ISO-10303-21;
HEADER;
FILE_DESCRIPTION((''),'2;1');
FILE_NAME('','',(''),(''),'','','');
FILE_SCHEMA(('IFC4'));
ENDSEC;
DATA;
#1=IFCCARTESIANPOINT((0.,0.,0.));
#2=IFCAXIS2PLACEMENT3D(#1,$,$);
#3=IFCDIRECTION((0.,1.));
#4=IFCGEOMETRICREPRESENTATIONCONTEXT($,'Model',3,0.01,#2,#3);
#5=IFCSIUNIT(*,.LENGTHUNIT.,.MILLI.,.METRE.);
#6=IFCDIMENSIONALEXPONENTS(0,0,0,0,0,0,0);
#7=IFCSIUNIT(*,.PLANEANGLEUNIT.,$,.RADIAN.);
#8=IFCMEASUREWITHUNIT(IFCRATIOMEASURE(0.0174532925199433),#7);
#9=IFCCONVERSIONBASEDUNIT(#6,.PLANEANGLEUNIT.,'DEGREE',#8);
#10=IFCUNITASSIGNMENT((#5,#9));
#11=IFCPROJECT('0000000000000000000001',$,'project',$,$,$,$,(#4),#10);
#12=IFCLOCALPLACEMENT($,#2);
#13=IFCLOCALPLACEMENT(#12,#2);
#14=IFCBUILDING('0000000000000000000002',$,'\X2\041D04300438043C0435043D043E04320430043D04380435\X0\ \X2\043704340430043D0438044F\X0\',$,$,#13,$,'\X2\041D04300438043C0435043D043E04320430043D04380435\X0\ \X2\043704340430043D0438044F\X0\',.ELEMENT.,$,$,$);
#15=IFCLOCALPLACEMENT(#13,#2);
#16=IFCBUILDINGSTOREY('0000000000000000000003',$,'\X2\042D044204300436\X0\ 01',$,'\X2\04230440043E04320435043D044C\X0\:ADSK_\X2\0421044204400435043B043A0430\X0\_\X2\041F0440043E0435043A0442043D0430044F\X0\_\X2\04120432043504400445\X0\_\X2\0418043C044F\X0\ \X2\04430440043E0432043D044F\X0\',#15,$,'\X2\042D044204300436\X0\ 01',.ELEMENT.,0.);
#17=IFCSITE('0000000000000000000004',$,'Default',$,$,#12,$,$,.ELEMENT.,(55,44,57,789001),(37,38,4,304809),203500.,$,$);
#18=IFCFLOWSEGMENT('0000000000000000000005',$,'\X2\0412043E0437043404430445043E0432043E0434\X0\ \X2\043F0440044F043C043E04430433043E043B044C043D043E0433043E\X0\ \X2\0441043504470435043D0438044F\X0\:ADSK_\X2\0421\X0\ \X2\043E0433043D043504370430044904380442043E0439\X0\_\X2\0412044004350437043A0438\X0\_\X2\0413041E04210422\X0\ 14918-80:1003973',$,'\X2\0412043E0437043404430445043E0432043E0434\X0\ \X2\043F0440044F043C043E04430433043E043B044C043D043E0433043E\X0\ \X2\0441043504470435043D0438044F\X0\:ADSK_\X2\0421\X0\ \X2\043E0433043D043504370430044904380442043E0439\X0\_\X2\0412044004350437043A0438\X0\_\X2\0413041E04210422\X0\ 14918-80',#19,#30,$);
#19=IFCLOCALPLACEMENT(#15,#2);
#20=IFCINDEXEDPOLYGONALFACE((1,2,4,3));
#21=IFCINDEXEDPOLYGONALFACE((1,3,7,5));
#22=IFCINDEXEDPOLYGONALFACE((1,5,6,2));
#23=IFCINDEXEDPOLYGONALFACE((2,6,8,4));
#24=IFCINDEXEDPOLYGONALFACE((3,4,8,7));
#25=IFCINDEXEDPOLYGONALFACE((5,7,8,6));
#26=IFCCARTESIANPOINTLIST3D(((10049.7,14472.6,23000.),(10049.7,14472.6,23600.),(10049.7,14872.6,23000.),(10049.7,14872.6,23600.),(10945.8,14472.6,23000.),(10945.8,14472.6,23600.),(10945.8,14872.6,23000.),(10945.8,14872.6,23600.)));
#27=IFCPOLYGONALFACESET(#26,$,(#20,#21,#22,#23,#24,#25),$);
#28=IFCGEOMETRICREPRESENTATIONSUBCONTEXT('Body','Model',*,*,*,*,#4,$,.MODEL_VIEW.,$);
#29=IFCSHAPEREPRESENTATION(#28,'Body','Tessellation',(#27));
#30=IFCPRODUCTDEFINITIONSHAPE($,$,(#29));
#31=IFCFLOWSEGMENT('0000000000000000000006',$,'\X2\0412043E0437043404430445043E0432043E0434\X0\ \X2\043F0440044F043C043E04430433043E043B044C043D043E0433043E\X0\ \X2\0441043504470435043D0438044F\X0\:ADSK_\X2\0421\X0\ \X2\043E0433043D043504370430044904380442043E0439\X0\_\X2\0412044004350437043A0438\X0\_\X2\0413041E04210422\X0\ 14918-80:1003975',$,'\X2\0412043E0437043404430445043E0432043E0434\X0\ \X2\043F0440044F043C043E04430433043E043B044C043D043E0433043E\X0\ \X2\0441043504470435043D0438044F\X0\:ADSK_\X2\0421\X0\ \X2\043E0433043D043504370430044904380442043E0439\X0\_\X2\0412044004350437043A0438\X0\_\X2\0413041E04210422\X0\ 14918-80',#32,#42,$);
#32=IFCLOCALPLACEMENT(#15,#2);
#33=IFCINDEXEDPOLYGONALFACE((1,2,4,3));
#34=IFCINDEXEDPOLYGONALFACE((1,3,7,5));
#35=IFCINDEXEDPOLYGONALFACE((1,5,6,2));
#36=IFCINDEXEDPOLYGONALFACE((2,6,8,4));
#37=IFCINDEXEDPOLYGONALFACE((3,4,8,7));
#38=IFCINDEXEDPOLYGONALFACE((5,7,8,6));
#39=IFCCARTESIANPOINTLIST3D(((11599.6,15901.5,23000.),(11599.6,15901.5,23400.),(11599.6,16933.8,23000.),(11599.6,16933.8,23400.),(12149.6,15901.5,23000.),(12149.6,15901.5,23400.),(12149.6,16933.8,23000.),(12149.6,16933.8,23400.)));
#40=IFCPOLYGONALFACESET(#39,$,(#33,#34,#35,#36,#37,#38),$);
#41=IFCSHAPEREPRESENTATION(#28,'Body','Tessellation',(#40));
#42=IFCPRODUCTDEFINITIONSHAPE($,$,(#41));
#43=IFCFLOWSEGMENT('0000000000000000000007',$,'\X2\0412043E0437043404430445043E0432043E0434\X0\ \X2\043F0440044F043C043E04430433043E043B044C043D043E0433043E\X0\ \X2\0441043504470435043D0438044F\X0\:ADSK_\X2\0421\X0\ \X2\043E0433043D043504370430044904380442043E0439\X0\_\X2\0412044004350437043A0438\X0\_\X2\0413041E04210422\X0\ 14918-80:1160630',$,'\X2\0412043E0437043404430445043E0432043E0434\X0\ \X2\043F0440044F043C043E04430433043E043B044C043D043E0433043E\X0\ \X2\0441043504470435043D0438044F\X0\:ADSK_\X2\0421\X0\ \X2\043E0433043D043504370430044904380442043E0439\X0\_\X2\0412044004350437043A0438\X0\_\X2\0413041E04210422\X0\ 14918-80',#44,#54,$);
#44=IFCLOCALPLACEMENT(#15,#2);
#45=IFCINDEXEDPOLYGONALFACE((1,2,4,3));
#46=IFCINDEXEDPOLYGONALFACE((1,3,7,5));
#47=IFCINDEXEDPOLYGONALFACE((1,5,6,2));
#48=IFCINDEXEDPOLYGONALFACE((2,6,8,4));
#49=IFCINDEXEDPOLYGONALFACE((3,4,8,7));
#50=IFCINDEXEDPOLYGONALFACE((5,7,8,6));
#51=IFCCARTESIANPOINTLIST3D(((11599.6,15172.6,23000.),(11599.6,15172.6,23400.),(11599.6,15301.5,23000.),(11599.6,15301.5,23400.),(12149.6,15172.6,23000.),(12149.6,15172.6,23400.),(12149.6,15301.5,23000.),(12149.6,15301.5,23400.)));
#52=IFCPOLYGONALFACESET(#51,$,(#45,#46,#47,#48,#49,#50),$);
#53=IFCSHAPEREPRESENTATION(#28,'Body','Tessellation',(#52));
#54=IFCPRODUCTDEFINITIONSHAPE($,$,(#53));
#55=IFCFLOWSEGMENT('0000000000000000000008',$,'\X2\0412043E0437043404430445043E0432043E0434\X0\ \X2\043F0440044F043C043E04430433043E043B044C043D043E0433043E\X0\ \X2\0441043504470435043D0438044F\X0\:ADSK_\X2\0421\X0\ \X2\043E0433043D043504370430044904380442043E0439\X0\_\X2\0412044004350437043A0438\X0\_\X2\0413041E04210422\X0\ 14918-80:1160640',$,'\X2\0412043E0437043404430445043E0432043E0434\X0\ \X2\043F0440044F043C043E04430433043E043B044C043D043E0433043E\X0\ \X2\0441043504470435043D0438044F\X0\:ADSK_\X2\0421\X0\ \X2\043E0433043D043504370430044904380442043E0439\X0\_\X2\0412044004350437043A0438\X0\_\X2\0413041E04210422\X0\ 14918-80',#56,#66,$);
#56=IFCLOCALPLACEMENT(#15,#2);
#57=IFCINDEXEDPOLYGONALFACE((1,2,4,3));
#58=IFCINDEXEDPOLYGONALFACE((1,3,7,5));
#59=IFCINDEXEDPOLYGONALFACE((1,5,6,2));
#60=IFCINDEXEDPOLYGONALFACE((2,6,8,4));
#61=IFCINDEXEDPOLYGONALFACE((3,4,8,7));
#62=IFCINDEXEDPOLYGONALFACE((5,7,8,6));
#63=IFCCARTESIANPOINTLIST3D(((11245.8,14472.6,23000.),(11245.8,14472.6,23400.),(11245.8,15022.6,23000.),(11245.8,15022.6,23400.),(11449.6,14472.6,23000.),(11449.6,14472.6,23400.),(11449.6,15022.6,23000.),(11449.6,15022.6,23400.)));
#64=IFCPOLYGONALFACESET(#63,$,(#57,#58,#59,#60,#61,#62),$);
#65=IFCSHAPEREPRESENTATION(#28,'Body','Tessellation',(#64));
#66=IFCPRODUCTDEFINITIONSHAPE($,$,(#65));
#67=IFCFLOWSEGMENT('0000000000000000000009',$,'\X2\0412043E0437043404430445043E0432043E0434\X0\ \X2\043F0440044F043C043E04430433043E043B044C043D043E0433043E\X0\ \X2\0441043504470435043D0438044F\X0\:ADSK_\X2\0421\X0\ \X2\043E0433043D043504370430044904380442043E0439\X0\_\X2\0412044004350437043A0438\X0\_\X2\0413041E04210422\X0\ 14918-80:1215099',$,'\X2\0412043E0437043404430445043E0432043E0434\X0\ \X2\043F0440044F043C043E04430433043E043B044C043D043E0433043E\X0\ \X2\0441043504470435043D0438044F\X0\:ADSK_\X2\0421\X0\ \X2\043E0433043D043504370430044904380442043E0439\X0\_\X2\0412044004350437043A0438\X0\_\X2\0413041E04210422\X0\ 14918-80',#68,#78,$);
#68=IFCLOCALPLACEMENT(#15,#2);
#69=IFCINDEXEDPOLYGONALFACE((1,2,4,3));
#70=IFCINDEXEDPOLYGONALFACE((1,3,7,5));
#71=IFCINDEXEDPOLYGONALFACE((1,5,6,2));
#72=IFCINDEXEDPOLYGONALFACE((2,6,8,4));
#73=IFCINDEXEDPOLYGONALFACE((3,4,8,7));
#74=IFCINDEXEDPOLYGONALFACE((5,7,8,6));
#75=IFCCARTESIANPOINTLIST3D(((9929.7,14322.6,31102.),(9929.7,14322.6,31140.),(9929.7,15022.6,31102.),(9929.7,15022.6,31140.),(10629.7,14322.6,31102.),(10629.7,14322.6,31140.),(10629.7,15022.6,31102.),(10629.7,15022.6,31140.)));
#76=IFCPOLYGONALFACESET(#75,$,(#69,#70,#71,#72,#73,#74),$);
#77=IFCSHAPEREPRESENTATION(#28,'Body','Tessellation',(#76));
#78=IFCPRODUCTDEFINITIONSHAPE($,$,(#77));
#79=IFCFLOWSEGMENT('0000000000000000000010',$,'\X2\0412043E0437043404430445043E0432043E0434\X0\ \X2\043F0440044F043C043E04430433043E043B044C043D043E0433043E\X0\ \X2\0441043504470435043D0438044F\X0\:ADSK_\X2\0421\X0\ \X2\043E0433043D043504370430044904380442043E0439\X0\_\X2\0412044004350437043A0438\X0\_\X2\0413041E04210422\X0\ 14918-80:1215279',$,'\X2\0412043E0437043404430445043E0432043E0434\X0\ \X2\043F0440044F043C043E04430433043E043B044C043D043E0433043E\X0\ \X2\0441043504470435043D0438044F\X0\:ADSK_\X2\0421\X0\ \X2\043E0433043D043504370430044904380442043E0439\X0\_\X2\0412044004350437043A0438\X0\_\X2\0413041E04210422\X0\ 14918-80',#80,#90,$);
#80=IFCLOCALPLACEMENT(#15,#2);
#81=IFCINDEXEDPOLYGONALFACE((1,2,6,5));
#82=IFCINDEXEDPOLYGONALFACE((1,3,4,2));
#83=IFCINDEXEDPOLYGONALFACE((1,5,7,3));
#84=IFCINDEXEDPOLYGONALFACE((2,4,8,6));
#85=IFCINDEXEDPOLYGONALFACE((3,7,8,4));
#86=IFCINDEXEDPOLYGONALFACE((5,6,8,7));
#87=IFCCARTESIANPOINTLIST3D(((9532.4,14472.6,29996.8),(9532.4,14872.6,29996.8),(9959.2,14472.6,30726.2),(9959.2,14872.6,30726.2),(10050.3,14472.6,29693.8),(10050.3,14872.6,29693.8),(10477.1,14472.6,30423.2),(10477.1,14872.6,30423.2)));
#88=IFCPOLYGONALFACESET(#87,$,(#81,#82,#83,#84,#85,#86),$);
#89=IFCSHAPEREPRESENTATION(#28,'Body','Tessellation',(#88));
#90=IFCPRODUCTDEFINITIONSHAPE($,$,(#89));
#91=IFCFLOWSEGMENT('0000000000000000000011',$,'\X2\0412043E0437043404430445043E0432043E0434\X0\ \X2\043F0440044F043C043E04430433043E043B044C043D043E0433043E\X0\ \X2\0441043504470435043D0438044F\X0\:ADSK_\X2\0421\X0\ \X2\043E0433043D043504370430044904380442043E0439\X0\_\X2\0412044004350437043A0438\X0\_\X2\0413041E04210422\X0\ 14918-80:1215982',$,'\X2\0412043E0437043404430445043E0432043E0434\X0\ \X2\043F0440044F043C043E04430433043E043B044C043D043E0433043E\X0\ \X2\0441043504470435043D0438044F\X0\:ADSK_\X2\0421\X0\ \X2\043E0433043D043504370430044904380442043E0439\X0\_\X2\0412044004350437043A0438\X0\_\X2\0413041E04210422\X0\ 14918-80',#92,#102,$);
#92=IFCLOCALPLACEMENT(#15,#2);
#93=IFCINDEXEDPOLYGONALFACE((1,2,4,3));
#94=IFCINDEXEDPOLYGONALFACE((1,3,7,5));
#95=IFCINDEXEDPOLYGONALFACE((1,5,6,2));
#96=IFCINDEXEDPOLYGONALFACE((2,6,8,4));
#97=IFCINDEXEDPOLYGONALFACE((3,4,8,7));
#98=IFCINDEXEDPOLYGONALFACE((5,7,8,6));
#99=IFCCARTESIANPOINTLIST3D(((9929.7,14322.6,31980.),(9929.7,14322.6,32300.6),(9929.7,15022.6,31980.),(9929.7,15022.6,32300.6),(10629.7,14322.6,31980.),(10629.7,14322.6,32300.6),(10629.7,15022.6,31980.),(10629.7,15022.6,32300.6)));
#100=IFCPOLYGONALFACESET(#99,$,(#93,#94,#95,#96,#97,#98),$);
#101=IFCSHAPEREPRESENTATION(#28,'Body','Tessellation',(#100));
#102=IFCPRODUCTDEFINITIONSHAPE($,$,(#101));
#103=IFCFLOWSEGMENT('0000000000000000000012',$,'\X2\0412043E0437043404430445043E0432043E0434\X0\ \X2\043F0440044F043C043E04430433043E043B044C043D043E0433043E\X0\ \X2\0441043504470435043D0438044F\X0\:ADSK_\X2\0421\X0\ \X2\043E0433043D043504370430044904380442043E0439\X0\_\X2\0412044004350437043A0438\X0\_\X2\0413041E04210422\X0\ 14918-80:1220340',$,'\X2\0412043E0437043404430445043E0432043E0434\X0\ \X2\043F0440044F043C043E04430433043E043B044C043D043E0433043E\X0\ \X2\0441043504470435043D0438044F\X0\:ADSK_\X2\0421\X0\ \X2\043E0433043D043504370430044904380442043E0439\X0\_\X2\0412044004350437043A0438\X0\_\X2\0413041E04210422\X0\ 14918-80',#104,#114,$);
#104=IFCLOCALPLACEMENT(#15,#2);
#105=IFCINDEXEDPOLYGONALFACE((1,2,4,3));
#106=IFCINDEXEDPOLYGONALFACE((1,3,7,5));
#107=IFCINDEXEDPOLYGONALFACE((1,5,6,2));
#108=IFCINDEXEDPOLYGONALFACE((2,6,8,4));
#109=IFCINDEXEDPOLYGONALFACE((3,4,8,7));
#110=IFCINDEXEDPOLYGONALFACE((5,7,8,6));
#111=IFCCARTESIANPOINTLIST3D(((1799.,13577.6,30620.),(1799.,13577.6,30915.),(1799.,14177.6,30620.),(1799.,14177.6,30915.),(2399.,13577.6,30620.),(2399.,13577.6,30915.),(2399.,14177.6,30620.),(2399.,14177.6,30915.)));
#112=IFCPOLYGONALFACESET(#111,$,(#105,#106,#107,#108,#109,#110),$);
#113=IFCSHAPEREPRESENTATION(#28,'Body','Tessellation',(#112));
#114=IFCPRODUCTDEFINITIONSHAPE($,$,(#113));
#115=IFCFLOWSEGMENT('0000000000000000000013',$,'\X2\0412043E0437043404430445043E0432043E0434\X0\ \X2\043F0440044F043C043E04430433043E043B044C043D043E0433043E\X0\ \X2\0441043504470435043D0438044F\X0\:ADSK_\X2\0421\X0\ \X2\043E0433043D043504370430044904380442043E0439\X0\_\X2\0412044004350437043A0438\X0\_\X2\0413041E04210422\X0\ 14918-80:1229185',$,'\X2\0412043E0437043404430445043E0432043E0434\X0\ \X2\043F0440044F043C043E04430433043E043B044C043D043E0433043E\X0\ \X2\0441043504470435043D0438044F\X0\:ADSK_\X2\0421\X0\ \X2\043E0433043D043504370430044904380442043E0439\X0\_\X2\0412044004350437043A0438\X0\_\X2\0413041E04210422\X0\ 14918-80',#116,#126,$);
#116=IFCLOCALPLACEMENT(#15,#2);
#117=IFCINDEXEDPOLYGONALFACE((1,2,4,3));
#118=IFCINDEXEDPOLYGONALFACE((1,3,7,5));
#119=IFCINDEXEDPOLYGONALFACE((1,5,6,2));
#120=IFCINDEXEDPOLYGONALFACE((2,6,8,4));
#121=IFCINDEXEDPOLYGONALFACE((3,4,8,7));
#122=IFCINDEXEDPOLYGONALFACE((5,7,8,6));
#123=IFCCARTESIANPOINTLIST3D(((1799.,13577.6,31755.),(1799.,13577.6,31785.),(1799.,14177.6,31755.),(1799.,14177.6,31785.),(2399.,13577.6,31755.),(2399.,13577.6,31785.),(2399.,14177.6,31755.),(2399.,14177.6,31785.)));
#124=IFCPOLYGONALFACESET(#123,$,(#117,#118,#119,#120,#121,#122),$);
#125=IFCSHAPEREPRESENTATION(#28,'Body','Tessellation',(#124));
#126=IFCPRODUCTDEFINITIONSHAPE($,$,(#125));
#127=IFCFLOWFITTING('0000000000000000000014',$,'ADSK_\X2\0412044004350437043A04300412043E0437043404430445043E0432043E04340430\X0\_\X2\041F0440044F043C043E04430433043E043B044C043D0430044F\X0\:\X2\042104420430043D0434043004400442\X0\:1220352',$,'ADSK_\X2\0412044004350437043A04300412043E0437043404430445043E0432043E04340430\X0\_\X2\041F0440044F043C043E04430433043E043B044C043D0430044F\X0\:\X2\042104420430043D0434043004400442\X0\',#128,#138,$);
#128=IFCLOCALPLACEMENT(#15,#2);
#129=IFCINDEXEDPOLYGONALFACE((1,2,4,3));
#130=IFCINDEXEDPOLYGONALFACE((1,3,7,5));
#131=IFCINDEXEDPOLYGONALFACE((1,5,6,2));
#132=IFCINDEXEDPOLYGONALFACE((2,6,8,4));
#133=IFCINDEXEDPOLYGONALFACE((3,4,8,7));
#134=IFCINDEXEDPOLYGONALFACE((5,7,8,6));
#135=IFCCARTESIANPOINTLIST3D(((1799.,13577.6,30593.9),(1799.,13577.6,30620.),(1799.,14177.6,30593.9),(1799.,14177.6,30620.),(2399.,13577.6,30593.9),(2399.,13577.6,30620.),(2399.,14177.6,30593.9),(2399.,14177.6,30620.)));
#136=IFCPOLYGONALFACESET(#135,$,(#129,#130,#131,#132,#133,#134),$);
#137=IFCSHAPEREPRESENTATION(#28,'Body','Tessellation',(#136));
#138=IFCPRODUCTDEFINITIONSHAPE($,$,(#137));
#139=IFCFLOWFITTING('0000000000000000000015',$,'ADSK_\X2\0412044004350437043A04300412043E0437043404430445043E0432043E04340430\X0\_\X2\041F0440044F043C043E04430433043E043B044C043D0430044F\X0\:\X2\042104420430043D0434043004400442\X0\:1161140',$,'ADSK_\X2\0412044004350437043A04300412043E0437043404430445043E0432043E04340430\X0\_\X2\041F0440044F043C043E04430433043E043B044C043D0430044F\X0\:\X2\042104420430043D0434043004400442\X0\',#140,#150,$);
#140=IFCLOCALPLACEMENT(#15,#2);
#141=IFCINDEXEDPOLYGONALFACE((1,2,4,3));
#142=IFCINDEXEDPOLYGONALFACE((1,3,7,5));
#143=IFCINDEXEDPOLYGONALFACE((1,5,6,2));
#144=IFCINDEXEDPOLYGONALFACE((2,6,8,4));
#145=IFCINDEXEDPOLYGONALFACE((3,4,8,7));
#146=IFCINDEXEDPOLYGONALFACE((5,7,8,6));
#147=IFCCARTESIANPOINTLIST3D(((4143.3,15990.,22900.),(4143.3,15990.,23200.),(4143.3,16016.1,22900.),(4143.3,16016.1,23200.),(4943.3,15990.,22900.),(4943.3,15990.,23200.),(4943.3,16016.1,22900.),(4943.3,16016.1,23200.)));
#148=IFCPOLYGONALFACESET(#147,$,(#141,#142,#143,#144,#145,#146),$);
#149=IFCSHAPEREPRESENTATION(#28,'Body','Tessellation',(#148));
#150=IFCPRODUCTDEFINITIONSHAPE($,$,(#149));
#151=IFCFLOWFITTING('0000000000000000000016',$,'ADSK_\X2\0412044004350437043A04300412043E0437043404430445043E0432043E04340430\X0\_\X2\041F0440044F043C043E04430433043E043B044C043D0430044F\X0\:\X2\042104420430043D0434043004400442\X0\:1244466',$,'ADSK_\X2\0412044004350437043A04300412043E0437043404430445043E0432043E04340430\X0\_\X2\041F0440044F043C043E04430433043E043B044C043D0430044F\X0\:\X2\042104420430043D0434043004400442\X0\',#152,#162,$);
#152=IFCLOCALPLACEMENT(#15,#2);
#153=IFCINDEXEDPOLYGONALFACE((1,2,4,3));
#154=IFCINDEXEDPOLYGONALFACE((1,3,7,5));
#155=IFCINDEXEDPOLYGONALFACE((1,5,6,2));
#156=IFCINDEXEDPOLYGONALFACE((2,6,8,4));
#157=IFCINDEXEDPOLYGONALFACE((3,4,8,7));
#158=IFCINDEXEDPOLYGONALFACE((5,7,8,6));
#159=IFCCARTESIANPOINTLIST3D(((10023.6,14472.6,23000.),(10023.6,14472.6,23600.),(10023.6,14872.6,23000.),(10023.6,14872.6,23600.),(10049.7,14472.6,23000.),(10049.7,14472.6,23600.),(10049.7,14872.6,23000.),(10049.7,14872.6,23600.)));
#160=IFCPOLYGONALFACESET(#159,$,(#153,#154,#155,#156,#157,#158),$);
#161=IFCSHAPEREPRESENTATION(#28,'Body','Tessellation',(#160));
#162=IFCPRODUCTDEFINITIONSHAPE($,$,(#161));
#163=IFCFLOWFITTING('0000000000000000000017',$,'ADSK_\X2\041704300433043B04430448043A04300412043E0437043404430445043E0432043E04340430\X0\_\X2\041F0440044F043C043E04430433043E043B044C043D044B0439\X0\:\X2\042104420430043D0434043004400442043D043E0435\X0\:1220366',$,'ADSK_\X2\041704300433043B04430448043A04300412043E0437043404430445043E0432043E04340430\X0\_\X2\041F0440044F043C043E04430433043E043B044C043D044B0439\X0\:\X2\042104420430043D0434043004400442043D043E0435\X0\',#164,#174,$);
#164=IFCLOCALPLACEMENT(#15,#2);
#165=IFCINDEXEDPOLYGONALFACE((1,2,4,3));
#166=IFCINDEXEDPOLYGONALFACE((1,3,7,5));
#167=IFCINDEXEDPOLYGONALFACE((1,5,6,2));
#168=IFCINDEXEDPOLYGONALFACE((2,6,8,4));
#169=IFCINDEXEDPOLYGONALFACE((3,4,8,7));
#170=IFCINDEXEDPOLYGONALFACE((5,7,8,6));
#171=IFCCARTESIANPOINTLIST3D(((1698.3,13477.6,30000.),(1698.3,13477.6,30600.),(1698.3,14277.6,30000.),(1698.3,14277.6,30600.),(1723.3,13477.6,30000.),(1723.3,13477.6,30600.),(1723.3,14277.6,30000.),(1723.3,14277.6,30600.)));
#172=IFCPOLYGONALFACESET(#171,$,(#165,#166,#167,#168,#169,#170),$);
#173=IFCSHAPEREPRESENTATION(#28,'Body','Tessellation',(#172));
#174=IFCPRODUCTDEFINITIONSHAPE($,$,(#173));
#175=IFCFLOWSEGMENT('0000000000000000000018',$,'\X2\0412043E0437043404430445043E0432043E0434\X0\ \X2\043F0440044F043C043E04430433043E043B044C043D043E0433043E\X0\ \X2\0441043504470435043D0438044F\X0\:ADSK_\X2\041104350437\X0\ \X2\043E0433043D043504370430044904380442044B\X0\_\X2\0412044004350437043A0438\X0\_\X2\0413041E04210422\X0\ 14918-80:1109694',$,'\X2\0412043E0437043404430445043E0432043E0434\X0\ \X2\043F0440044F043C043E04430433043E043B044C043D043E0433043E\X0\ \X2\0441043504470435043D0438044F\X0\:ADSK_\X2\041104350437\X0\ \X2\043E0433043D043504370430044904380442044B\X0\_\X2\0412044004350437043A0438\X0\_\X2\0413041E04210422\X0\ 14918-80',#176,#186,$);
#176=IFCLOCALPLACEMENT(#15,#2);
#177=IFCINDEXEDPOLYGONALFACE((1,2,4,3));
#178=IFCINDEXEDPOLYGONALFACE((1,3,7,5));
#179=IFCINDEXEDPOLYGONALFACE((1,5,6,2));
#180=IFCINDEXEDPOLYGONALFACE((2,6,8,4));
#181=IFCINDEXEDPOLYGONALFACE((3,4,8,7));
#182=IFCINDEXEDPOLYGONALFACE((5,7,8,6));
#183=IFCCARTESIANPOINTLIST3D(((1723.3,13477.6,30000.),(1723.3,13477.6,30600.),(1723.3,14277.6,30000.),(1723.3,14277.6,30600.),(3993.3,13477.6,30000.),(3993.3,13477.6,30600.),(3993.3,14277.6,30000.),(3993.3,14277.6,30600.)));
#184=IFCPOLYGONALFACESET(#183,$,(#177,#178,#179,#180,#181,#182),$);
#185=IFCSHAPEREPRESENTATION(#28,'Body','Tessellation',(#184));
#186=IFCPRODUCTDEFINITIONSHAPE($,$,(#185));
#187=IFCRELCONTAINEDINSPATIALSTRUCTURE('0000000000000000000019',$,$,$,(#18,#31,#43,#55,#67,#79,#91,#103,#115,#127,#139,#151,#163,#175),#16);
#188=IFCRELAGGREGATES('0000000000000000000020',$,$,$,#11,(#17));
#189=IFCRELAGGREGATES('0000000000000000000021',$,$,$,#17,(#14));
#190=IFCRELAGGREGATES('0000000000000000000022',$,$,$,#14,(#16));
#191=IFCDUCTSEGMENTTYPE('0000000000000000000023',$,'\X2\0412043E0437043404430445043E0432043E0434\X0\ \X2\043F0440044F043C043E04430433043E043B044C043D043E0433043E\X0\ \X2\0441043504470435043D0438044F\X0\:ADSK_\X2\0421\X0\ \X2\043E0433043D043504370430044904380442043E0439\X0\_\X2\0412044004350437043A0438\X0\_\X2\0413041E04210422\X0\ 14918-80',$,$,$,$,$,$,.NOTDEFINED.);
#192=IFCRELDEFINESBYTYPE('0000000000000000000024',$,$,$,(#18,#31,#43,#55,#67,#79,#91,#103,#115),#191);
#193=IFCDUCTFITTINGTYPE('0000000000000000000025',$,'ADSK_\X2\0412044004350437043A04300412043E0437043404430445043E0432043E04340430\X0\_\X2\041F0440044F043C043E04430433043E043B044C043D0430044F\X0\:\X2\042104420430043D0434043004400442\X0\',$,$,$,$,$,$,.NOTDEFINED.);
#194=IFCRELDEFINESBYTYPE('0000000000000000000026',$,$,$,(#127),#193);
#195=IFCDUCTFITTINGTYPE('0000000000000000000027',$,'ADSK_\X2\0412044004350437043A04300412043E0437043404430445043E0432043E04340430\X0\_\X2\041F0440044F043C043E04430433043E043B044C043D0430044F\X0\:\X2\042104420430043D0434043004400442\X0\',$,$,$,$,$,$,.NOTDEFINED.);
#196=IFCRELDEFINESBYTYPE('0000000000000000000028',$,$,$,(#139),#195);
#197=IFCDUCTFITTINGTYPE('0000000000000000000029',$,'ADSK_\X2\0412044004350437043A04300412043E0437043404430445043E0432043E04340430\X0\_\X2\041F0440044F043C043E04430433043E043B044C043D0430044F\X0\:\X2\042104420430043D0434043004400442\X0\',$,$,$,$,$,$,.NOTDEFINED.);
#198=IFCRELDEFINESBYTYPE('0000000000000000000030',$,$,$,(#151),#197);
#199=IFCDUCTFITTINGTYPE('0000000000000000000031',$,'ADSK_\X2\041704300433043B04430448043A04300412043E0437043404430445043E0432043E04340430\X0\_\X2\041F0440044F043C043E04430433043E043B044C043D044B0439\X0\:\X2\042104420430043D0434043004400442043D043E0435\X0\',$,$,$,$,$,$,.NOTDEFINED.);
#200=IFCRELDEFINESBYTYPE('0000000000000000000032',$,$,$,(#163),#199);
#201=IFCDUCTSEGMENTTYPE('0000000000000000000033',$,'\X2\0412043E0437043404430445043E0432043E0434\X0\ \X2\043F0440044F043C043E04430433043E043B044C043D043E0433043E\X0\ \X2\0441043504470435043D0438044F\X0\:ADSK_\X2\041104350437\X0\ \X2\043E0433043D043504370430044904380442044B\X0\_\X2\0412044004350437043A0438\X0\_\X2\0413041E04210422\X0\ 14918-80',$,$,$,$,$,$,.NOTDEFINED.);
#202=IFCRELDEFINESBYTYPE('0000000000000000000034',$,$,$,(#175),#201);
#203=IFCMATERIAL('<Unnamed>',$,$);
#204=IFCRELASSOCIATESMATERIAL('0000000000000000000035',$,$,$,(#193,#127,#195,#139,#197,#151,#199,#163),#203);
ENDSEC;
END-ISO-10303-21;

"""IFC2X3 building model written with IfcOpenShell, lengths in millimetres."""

from ifc_helpers import new_model, entity, si_unit, converted_unit, direction, frame, frame_2d, origin, origin_2d_with_axis, place, context, subcontext, project, spatial, rectangle, extrude, source, transform, mapped, material, type_object, type_shapes, element, save


model = new_model("IFC2X3")

# Units and contexts
model_context = context("Model", 3, precision=0.01, world=origin(), true_north=direction((0.0, 1.0)))
body_context = subcontext(model_context, "Body", "Model", "MODEL_VIEW")
ifc_project = project(units=[si_unit("LENGTHUNIT", "METRE", prefix="MILLI"), converted_unit("PLANEANGLEUNIT", "DEGREE", entity("IfcRatioMeasure", 0.0174532925199433), si_unit("PLANEANGLEUNIT", "RADIAN"), dimensions=[0, 0, 0, 0, 0, 0, 0])], contexts=[model_context])

# Site, building, storey
site_placement = place(None, frame((0.0, 0.0, 0.0)))
site = spatial("IfcSite", under=ifc_project, at=site_placement, Name="Default", CompositionType="ELEMENT", RefLatitude=(55, 44, 57, 789001), RefLongitude=(37, 38, 4, 304809), RefElevation=203500.0)
building_placement = place(site_placement, origin())
building = spatial("IfcBuilding", under=site, at=building_placement, Name="Наименование здания", LongName="Наименование здания", CompositionType="ELEMENT")
storey_placement = place(building_placement, origin())
storey = spatial("IfcBuildingStorey", under=building, at=storey_placement, Name="Этаж 01", ObjectType="Уровень:ADSK_Стрелка_Проектная_Вверх_Имя уровня", LongName="Этаж 01", CompositionType="ELEMENT", Elevation=0.0)

# Flow segments
duct_segment_type_1 = type_object("IfcDuctSegmentType", Name="Воздуховод прямоугольного сечения:ADSK_С огнезащитой_Врезки_ГОСТ 14918-80", PredefinedType="NOTDEFINED")
flow_segment_1_placement = place(storey_placement, frame((10049.7, 14472.6, 23000.0)))
element("IfcFlowSegment", 1, at=flow_segment_1_placement, inside=storey, type_object=duct_segment_type_1, Name="Воздуховод прямоугольного сечения:ADSK_С огнезащитой_Врезки_ГОСТ 14918-80:1003973", ObjectType="Воздуховод прямоугольного сечения:ADSK_С огнезащитой_Врезки_ГОСТ 14918-80", context=body_context, shape_type="SweptSolid", body=[
    extrude(rectangle(XDim=896.0, YDim=400.0, at=frame_2d((0.0, 0.0), x_axis=(1.0, 0.0))), frame((448.0, 200.0, 0.0)), (0.0, 0.0, 1.0), 600.0),
])
flow_segment_2_placement = place(storey_placement, frame((11599.6, 15901.5, 23000.0)))
element("IfcFlowSegment", 2, at=flow_segment_2_placement, inside=storey, type_object=duct_segment_type_1, Name="Воздуховод прямоугольного сечения:ADSK_С огнезащитой_Врезки_ГОСТ 14918-80:1003975", ObjectType="Воздуховод прямоугольного сечения:ADSK_С огнезащитой_Врезки_ГОСТ 14918-80", context=body_context, shape_type="SweptSolid", body=[
    extrude(rectangle(XDim=1032.3, YDim=550.0, at=frame_2d((0.0, 0.0), x_axis=(1.0, 0.0))), frame((275.0, 516.1, 0.0), z_axis=(0.0, 0.0, 1.0), x_axis=(0.0, 1.0, 0.0)), (0.0, 0.0, 1.0), 400.0),
])
flow_segment_3_placement = place(storey_placement, frame((11599.6, 15172.6, 23000.0)))
element("IfcFlowSegment", 3, at=flow_segment_3_placement, inside=storey, type_object=duct_segment_type_1, Name="Воздуховод прямоугольного сечения:ADSK_С огнезащитой_Врезки_ГОСТ 14918-80:1160630", ObjectType="Воздуховод прямоугольного сечения:ADSK_С огнезащитой_Врезки_ГОСТ 14918-80", context=body_context, shape_type="SweptSolid", body=[
    extrude(rectangle(XDim=128.9, YDim=550.0, at=frame_2d((0.0, 0.0), x_axis=(1.0, 0.0))), frame((275.0, 64.5, 0.0), z_axis=(0.0, 0.0, 1.0), x_axis=(0.0, -1.0, 0.0)), (0.0, 0.0, 1.0), 400.0),
])
flow_segment_4_placement = place(storey_placement, frame((11245.8, 14472.6, 23000.0)))
element("IfcFlowSegment", 4, at=flow_segment_4_placement, inside=storey, type_object=duct_segment_type_1, Name="Воздуховод прямоугольного сечения:ADSK_С огнезащитой_Врезки_ГОСТ 14918-80:1160640", ObjectType="Воздуховод прямоугольного сечения:ADSK_С огнезащитой_Врезки_ГОСТ 14918-80", context=body_context, shape_type="SweptSolid", body=[
    extrude(rectangle(XDim=203.9, YDim=550.0, at=frame_2d((0.0, 0.0), x_axis=(1.0, 0.0))), frame((101.9, 275.0, 0.0)), (0.0, 0.0, 1.0), 400.0),
])
flow_segment_5_placement = place(storey_placement, frame((9929.7, 14322.6, 31102.0)))
element("IfcFlowSegment", 5, at=flow_segment_5_placement, inside=storey, type_object=duct_segment_type_1, Name="Воздуховод прямоугольного сечения:ADSK_С огнезащитой_Врезки_ГОСТ 14918-80:1215099", ObjectType="Воздуховод прямоугольного сечения:ADSK_С огнезащитой_Врезки_ГОСТ 14918-80", context=body_context, shape_type="SweptSolid", body=[
    extrude(rectangle(XDim=700.0, YDim=700.0, at=frame_2d((0.0, 0.0), x_axis=(1.0, 0.0))), frame((350.0, 350.0, 0.0), z_axis=(0.0, 0.0, 1.0), x_axis=(0.0, 1.0, 0.0)), (0.0, 0.0, 1.0), 38.0),
])
flow_segment_6_placement = place(storey_placement, frame((9532.4, 14472.6, 29693.8)))
element("IfcFlowSegment", 6, at=flow_segment_6_placement, inside=storey, type_object=duct_segment_type_1, Name="Воздуховод прямоугольного сечения:ADSK_С огнезащитой_Врезки_ГОСТ 14918-80:1215279", ObjectType="Воздуховод прямоугольного сечения:ADSK_С огнезащитой_Врезки_ГОСТ 14918-80", context=body_context, shape_type="SweptSolid", body=[
    extrude(rectangle(XDim=600.0, YDim=400.0, at=frame_2d((0.0, 0.0), x_axis=(0.0, 1.0))), frame((258.9, 200.0, 151.5), z_axis=(0.505012, 0.0, 0.863112), x_axis=(0.0, 1.0, 0.0)), (0.0, 0.0, 1.0), 845.1),
])
flow_segment_7_placement = place(storey_placement, frame((9929.7, 14322.6, 31980.0)))
element("IfcFlowSegment", 7, at=flow_segment_7_placement, inside=storey, type_object=duct_segment_type_1, Name="Воздуховод прямоугольного сечения:ADSK_С огнезащитой_Врезки_ГОСТ 14918-80:1215982", ObjectType="Воздуховод прямоугольного сечения:ADSK_С огнезащитой_Врезки_ГОСТ 14918-80", context=body_context, shape_type="SweptSolid", body=[
    extrude(rectangle(XDim=700.0, YDim=700.0, at=frame_2d((0.0, 0.0), x_axis=(1.0, 0.0))), frame((350.0, 350.0, 0.0), z_axis=(0.0, 0.0, 1.0), x_axis=(0.0, 1.0, 0.0)), (0.0, 0.0, 1.0), 320.6),
])
flow_segment_8_placement = place(storey_placement, frame((1799.0, 13577.6, 30620.0)))
element("IfcFlowSegment", 8, at=flow_segment_8_placement, inside=storey, type_object=duct_segment_type_1, Name="Воздуховод прямоугольного сечения:ADSK_С огнезащитой_Врезки_ГОСТ 14918-80:1220340", ObjectType="Воздуховод прямоугольного сечения:ADSK_С огнезащитой_Врезки_ГОСТ 14918-80", context=body_context, shape_type="SweptSolid", body=[
    extrude(rectangle(XDim=600.0, YDim=600.0, at=frame_2d((0.0, 0.0), x_axis=(1.0, 0.0))), frame((300.0, 300.0, 0.0), z_axis=(0.0, 0.0, 1.0), x_axis=(0.0, -1.0, 0.0)), (0.0, 0.0, 1.0), 295.0),
])
flow_segment_9_placement = place(storey_placement, frame((1799.0, 13577.6, 31755.0)))
element("IfcFlowSegment", 9, at=flow_segment_9_placement, inside=storey, type_object=duct_segment_type_1, Name="Воздуховод прямоугольного сечения:ADSK_С огнезащитой_Врезки_ГОСТ 14918-80:1229185", ObjectType="Воздуховод прямоугольного сечения:ADSK_С огнезащитой_Врезки_ГОСТ 14918-80", context=body_context, shape_type="SweptSolid", body=[
    extrude(rectangle(XDim=600.0, YDim=600.0, at=frame_2d((0.0, 0.0), x_axis=(1.0, 0.0))), frame((300.0, 300.0, 0.0), z_axis=(0.0, 0.0, 1.0), x_axis=(0.0, -1.0, 0.0)), (0.0, 0.0, 1.0), 30.0),
])

# Flow fittings
ifc_material_1 = material(Name="<Unnamed>")
duct_fitting_type_1 = type_object("IfcDuctFittingType", Name="ADSK_ВрезкаВоздуховода_Прямоугольная:Стандарт", PredefinedType="NOTDEFINED", material=ifc_material_1)
shared_shape_1 = source(origin(), body_context, "Body", "SweptSolid", [
    extrude(rectangle(XDim=600.0, YDim=26.1, at=origin_2d_with_axis()), frame((7.0, 0.0, -300.0), z_axis=(0.0, 0.0, 1.0), x_axis=(0.0, -1.0, 0.0)), (0.0, 0.0, 1.0), 600.0),
])
type_shapes(duct_fitting_type_1, [shared_shape_1])
flow_fitting_1_placement = place(storey_placement, frame((2099.0, 13877.6, 30600.0), z_axis=(0.0, -1.0, 0.0), x_axis=(0.0, 0.0, 1.0)))
element("IfcFlowFitting", 10, at=flow_fitting_1_placement, inside=storey, type_object=duct_fitting_type_1, material=ifc_material_1, Name="ADSK_ВрезкаВоздуховода_Прямоугольная:Стандарт:1220352", ObjectType="ADSK_ВрезкаВоздуховода_Прямоугольная:Стандарт", context=body_context, shape_type="MappedRepresentation", body=[
    mapped(shared_shape_1, transform((0.0, 0.0, 0.0), scale=1.0)),
])
duct_fitting_type_2 = type_object("IfcDuctFittingType", Name="ADSK_ВрезкаВоздуховода_Прямоугольная:Стандарт", PredefinedType="NOTDEFINED", material=ifc_material_1)
shared_shape_2 = source(origin(), body_context, "Body", "SweptSolid", [
    extrude(rectangle(XDim=26.1, YDim=300.0, at=frame_2d((0.0, 0.0), x_axis=(1.0, 0.0))), frame((7.0, 0.0, -400.0)), (0.0, 0.0, 1.0), 800.0),
])
type_shapes(duct_fitting_type_2, [shared_shape_2])
flow_fitting_2_placement = place(storey_placement, frame((4543.3, 16010.0, 23050.0), z_axis=(-1.0, 0.0, 0.0), x_axis=(0.0, -1.0, 0.0)))
element("IfcFlowFitting", 11, at=flow_fitting_2_placement, inside=storey, type_object=duct_fitting_type_2, material=ifc_material_1, Name="ADSK_ВрезкаВоздуховода_Прямоугольная:Стандарт:1161140", ObjectType="ADSK_ВрезкаВоздуховода_Прямоугольная:Стандарт", context=body_context, shape_type="MappedRepresentation", body=[
    mapped(shared_shape_2, transform((0.0, 0.0, 0.0), scale=1.0)),
])
duct_fitting_type_3 = type_object("IfcDuctFittingType", Name="ADSK_ВрезкаВоздуховода_Прямоугольная:Стандарт", PredefinedType="NOTDEFINED", material=ifc_material_1)
shared_shape_3 = source(origin(), body_context, "Body", "SweptSolid", [
    extrude(rectangle(XDim=600.0, YDim=26.1, at=origin_2d_with_axis()), frame((7.0, 0.0, -200.0), z_axis=(0.0, 0.0, 1.0), x_axis=(0.0, -1.0, 0.0)), (0.0, 0.0, 1.0), 400.0),
])
type_shapes(duct_fitting_type_3, [shared_shape_3])
flow_fitting_3_placement = place(storey_placement, frame((10029.7, 14672.6, 23300.0), z_axis=(0.0, -1.0, 0.0), x_axis=(1.0, 0.0, 0.0)))
element("IfcFlowFitting", 12, at=flow_fitting_3_placement, inside=storey, type_object=duct_fitting_type_3, material=ifc_material_1, Name="ADSK_ВрезкаВоздуховода_Прямоугольная:Стандарт:1244466", ObjectType="ADSK_ВрезкаВоздуховода_Прямоугольная:Стандарт", context=body_context, shape_type="MappedRepresentation", body=[
    mapped(shared_shape_3, transform((0.0, 0.0, 0.0), scale=1.0)),
])
duct_fitting_type_4 = type_object("IfcDuctFittingType", Name="ADSK_ЗаглушкаВоздуховода_Прямоугольный:Стандартное", PredefinedType="NOTDEFINED", material=ifc_material_1)
shared_shape_4 = source(origin(), body_context, "Body", "SweptSolid", [
    extrude(rectangle(XDim=25.0, YDim=800.0, at=frame_2d((0.0, 0.0), x_axis=(1.0, 0.0))), frame((12.5, 0.0, -300.0)), (0.0, 0.0, 1.0), 600.0),
])
type_shapes(duct_fitting_type_4, [shared_shape_4])
flow_fitting_4_placement = place(storey_placement, frame((1723.3, 13877.6, 30300.0), z_axis=(0.0, 0.0, 1.0), x_axis=(-1.0, 0.0, 0.0)))
element("IfcFlowFitting", 13, at=flow_fitting_4_placement, inside=storey, type_object=duct_fitting_type_4, material=ifc_material_1, Name="ADSK_ЗаглушкаВоздуховода_Прямоугольный:Стандартное:1220366", ObjectType="ADSK_ЗаглушкаВоздуховода_Прямоугольный:Стандартное", context=body_context, shape_type="MappedRepresentation", body=[
    mapped(shared_shape_4, transform((0.0, 0.0, 0.0), scale=1.0)),
])

# Flow segment
duct_segment_type_2 = type_object("IfcDuctSegmentType", Name="Воздуховод прямоугольного сечения:ADSK_Без огнезащиты_Врезки_ГОСТ 14918-80", PredefinedType="NOTDEFINED")
flow_segment_10_placement = place(storey_placement, frame((1723.3, 13477.6, 30000.0)))
element("IfcFlowSegment", 14, at=flow_segment_10_placement, inside=storey, type_object=duct_segment_type_2, Name="Воздуховод прямоугольного сечения:ADSK_Без огнезащиты_Врезки_ГОСТ 14918-80:1109694", ObjectType="Воздуховод прямоугольного сечения:ADSK_Без огнезащиты_Врезки_ГОСТ 14918-80", context=body_context, shape_type="SweptSolid", body=[
    extrude(rectangle(XDim=2270.0, YDim=800.0, at=frame_2d((0.0, 0.0), x_axis=(1.0, 0.0))), frame((1135.0, 400.0, 0.0), z_axis=(0.0, 0.0, 1.0), x_axis=(-1.0, 0.0, 0.0)), (0.0, 0.0, 1.0), 600.0),
])

save(model, "model.ifc")
